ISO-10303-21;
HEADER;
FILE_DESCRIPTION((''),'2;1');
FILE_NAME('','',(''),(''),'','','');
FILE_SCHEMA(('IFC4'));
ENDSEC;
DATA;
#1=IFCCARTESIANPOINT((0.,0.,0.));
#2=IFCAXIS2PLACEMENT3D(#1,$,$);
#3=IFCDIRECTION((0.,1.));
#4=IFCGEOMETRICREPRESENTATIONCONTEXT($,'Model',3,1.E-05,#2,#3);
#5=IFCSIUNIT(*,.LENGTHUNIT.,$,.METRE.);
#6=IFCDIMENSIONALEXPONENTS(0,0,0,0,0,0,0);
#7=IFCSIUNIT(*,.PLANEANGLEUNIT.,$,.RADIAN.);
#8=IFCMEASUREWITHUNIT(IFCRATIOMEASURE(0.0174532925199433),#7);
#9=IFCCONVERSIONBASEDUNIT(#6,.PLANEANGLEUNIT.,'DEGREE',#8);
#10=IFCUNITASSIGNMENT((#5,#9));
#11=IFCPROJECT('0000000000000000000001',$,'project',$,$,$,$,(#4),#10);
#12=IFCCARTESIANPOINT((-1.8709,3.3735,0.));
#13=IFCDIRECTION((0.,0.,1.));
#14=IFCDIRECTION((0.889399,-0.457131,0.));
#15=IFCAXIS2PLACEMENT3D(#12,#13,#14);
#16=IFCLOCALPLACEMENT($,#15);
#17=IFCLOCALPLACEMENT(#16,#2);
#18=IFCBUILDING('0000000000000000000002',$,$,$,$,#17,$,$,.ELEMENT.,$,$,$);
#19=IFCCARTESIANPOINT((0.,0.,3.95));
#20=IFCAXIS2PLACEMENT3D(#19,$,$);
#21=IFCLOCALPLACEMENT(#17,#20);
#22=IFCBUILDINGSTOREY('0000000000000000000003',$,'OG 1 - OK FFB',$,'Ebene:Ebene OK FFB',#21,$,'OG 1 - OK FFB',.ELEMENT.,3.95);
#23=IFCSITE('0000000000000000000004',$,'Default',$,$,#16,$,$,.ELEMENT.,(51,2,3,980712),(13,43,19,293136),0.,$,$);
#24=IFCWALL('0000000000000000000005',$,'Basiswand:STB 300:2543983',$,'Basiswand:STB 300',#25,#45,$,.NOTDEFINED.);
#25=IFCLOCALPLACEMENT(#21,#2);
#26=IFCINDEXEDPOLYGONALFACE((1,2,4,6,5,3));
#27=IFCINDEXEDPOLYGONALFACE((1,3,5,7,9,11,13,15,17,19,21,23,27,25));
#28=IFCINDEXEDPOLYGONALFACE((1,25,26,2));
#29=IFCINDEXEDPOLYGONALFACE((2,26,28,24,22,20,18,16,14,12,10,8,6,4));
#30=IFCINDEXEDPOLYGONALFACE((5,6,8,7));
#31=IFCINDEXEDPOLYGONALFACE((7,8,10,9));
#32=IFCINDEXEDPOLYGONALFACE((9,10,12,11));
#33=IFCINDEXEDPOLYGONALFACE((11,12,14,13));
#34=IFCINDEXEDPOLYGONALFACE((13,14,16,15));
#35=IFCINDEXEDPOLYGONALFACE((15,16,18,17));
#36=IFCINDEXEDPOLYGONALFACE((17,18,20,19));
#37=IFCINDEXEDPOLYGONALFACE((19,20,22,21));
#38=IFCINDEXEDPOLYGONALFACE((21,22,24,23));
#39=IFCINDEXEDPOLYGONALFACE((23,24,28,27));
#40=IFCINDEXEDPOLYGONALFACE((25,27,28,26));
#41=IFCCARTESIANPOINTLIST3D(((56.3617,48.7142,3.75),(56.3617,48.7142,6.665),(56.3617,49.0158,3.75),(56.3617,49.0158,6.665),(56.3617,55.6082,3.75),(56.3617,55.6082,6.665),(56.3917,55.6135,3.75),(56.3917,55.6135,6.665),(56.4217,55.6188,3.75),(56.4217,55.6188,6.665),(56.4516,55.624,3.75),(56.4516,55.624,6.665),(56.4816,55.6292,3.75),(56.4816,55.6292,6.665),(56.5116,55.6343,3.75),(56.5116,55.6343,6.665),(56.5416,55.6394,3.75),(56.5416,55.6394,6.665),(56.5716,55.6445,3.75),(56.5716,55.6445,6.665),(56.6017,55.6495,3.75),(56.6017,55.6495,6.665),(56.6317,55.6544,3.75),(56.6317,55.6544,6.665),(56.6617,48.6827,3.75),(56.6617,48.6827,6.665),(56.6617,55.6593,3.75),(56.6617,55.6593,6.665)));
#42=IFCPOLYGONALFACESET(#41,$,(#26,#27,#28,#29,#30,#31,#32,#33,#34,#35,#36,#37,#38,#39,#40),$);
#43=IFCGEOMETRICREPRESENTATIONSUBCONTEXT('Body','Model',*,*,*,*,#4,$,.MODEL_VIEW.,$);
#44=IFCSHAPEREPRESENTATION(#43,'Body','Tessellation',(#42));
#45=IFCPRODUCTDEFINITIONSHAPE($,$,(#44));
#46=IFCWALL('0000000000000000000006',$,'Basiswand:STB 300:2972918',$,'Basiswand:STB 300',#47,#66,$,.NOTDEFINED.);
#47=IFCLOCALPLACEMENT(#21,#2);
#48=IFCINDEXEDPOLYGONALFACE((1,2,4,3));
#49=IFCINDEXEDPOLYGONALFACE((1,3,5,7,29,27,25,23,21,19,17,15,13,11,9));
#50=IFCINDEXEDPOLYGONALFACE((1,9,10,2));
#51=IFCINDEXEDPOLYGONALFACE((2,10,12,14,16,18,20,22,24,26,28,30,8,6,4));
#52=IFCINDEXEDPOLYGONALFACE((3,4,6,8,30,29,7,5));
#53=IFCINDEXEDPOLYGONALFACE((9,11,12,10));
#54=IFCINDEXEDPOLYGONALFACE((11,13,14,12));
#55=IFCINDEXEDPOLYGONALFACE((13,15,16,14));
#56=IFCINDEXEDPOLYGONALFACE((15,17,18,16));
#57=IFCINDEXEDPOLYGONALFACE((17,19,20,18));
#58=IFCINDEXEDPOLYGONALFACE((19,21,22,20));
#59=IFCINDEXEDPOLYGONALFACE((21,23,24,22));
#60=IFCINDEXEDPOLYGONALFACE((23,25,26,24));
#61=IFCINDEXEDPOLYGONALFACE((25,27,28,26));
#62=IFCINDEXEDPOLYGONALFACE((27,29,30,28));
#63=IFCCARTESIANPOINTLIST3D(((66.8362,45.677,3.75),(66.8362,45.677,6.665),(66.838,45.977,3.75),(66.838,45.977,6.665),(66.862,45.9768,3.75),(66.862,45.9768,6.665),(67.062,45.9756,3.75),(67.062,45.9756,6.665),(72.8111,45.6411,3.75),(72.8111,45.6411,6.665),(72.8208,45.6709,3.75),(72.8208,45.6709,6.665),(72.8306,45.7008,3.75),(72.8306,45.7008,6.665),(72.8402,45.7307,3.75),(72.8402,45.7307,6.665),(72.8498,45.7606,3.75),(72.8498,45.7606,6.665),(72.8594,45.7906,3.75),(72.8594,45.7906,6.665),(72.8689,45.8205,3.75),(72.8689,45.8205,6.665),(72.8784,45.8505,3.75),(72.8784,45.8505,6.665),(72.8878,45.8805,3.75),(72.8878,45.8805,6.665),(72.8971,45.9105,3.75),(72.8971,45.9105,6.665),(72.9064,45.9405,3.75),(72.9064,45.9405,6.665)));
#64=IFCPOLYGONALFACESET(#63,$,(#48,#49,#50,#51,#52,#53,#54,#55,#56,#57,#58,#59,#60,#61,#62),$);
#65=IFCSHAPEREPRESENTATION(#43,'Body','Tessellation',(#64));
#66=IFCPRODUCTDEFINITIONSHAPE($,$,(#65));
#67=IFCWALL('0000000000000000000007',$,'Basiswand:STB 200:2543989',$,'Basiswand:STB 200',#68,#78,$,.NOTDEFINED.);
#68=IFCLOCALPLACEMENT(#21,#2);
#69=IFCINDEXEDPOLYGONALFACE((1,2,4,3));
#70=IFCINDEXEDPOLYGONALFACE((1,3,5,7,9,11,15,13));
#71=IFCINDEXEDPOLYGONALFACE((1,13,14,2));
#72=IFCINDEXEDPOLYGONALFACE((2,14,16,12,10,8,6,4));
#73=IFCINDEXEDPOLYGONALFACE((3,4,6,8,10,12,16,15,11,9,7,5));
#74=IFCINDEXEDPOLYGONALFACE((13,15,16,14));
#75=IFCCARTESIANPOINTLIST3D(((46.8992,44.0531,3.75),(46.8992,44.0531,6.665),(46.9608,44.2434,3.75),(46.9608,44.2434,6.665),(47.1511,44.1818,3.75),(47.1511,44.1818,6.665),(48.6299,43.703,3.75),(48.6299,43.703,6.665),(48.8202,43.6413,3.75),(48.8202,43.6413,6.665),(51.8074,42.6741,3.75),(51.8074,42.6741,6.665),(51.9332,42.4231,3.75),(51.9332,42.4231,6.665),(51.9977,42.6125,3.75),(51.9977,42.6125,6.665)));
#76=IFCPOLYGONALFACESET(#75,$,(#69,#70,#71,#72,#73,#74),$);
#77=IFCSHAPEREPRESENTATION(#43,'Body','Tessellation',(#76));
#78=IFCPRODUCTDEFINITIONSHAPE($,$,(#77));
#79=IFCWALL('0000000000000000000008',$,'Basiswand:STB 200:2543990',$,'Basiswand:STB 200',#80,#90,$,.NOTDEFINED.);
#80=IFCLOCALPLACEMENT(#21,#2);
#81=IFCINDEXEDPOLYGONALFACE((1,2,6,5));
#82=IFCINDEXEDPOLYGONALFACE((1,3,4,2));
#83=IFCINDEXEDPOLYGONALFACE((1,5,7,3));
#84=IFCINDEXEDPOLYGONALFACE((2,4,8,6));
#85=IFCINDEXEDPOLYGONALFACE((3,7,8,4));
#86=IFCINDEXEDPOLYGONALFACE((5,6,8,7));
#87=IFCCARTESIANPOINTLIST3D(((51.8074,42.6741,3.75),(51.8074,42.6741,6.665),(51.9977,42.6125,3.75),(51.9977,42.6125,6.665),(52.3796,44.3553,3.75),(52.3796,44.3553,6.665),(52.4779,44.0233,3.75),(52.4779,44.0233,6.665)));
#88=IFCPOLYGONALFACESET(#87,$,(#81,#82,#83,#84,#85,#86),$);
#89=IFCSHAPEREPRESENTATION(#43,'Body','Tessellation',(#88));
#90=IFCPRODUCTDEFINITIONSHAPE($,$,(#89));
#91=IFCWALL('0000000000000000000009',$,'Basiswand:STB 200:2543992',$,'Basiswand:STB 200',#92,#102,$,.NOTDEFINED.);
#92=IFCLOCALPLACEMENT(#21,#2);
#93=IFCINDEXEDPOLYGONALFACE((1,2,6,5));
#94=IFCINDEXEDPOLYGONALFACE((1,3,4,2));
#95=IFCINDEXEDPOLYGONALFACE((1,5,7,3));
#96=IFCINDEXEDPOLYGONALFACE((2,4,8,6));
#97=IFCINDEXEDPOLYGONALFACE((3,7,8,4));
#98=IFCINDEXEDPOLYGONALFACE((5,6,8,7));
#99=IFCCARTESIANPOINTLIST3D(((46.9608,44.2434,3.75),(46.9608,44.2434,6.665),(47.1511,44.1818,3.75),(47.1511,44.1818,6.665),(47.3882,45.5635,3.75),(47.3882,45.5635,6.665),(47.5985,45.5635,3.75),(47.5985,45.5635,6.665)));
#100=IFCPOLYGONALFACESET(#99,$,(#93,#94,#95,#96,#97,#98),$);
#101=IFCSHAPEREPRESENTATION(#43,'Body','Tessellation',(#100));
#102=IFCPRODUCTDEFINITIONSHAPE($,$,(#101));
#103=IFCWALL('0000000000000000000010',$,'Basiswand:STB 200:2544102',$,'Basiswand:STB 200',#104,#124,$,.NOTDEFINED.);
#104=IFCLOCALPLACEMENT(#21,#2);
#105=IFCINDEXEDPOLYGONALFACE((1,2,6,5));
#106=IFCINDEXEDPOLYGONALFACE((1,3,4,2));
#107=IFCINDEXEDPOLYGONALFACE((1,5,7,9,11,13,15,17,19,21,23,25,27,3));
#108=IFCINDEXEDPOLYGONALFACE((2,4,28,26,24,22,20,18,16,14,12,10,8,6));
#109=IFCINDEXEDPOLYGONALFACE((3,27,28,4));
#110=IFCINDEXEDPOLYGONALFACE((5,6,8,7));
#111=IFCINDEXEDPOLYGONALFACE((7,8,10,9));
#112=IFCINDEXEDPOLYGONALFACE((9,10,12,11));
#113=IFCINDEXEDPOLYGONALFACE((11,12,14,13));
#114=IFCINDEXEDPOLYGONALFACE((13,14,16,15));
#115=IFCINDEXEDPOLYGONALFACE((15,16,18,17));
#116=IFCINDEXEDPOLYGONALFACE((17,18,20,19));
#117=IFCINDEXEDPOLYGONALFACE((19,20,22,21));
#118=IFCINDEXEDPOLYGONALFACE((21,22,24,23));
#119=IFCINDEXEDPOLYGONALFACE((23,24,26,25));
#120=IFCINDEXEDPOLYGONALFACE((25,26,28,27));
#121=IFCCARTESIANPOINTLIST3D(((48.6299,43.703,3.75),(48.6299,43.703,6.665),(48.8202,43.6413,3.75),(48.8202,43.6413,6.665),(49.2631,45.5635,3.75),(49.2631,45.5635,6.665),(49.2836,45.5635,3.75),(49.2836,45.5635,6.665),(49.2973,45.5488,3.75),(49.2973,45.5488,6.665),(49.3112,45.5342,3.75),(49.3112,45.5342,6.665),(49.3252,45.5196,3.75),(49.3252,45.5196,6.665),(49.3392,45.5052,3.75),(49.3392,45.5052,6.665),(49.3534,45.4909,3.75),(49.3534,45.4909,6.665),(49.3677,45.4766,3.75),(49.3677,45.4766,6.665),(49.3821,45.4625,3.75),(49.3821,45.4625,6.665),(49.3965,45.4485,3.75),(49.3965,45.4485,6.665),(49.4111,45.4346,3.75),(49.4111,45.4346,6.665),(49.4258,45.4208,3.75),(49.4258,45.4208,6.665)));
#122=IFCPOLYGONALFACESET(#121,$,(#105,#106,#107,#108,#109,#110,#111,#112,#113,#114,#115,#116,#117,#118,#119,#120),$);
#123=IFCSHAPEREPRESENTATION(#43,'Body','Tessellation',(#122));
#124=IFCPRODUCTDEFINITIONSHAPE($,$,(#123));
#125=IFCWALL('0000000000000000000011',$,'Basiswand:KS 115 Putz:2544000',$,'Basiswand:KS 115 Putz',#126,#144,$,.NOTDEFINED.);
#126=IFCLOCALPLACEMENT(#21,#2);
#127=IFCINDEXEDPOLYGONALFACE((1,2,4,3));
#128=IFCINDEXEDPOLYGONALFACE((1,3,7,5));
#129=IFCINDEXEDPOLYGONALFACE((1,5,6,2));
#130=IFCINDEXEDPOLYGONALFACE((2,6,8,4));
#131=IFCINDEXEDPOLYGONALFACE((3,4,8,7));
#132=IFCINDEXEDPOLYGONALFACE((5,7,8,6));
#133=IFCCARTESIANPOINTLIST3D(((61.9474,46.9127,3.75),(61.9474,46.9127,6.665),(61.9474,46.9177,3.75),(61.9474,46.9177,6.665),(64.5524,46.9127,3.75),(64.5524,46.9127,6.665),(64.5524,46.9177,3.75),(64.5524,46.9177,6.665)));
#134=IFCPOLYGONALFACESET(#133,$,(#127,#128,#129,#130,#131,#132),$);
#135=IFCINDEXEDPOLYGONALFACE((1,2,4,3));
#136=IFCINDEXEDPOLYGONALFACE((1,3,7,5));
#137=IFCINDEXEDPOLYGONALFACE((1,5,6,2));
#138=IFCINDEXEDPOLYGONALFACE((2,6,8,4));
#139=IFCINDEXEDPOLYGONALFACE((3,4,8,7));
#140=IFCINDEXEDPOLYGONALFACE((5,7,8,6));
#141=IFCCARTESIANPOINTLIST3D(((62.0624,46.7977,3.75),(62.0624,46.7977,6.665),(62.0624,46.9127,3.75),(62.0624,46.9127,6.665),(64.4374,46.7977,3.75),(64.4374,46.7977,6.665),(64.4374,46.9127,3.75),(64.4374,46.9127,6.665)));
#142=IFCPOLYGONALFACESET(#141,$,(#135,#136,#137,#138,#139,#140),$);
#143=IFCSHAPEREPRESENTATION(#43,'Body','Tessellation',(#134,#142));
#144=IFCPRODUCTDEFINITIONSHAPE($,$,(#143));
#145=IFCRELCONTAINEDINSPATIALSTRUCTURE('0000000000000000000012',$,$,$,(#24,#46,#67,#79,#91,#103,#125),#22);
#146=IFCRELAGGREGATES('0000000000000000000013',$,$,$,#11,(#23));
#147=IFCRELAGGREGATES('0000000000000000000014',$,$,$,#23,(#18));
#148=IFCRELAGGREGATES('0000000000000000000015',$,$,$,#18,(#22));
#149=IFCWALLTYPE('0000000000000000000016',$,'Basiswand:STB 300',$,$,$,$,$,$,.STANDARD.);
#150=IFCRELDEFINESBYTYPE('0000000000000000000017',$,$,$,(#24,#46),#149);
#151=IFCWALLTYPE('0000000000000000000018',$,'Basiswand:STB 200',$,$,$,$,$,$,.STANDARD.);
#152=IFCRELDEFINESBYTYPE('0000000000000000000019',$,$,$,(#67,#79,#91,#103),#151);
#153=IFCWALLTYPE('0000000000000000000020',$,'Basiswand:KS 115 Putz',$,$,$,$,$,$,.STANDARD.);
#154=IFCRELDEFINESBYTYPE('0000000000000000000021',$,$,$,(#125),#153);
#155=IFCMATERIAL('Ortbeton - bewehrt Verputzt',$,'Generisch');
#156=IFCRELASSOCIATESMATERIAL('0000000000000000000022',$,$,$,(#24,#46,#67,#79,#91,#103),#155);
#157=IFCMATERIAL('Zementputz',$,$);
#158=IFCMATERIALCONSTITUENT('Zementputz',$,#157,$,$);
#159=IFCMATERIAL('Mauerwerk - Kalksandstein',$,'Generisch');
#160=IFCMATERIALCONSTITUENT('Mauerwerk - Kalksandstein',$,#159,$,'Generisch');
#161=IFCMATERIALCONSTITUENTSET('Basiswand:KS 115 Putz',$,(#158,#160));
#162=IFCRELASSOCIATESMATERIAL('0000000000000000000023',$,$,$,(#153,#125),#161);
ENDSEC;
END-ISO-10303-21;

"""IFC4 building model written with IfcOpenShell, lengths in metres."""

from ifc_helpers import new_model, entity, si_unit, converted_unit, direction, frame, origin, place, context, subcontext, project, spatial, indexed_curve, outline, extrude, material, constituent, constituent_set, type_object, element, save


model = new_model("IFC4")

# Units and contexts
model_context = context("Model", 3, precision=1e-05, world=origin(), true_north=direction((0.0, 1.0)))
body_context = subcontext(model_context, "Body", "Model", "MODEL_VIEW")
ifc_project = project(units=[si_unit("LENGTHUNIT", "METRE"), converted_unit("PLANEANGLEUNIT", "DEGREE", entity("IfcRatioMeasure", 0.0174532925199433), si_unit("PLANEANGLEUNIT", "RADIAN"), dimensions=[0, 0, 0, 0, 0, 0, 0])], contexts=[model_context])

# Site, building, storey
site_placement = place(None, frame((-1.8709, 3.3735, 0.0), z_axis=(0.0, 0.0, 1.0), x_axis=(0.889399, -0.457131, 0.0)))
site = spatial("IfcSite", under=ifc_project, at=site_placement, Name="Default", CompositionType="ELEMENT", RefLatitude=(51, 2, 3, 980712), RefLongitude=(13, 43, 19, 293136), RefElevation=0.0)
building_placement = place(site_placement, origin())
building = spatial("IfcBuilding", under=site, at=building_placement, CompositionType="ELEMENT")
storey_placement = place(building_placement, frame((0.0, 0.0, 3.95)))
storey = spatial("IfcBuildingStorey", under=building, at=storey_placement, Name="OG 1 - OK FFB", ObjectType="Ebene:Ebene OK FFB", LongName="OG 1 - OK FFB", CompositionType="ELEMENT", Elevation=3.95)

# Shared definitions
ifc_material_1 = material(Name="Ortbeton - bewehrt Verputzt", Category="Generisch")

# Walls
wall_type_1 = type_object("IfcWallType", Name="Basiswand:STB 300", PredefinedType="STANDARD")
wall_1_placement = place(storey_placement, frame((56.5117, 48.6827, 3.75), z_axis=(0.0, 0.0, 1.0), x_axis=(0.0, 1.0, 0.0)))
element("IfcWall", 1, at=wall_1_placement, inside=storey, type_object=wall_type_1, material=ifc_material_1, Name="Basiswand:STB 300:2543983", ObjectType="Basiswand:STB 300", PredefinedType="NOTDEFINED", context=body_context, shape_type="SweptSolid", body=[
    extrude(outline(indexed_curve([(6.9767, -0.15), (6.9718, -0.12), (6.9668, -0.0899), (6.9618, -0.0599), (6.9568, -0.0299), (6.9517, 0.0001), (6.9465, 0.0301), (6.9414, 0.0601), (6.9361, 0.0901), (6.9308, 0.12), (6.9255, 0.15), (0.3332, 0.15), (0.0315, 0.15), (0.0, -0.15), (6.9767, -0.15)], self_intersect=False)), origin(), (0.0, 0.0, 1.0), 2.915),
])
wall_2_placement = place(storey_placement, frame((66.8371, 45.827, 3.75), z_axis=(0.0, 0.0, 1.0), x_axis=(0.999982, -0.006008, 0.0)))
element("IfcWall", 2, at=wall_2_placement, inside=storey, type_object=wall_type_1, material=ifc_material_1, Name="Basiswand:STB 300:2972918", ObjectType="Basiswand:STB 300", PredefinedType="NOTDEFINED", context=body_context, shape_type="SweptSolid", body=[
    extrude(outline(indexed_curve([(5.975, -0.15), (5.9846, -0.1201), (5.9941, -0.0901), (6.0036, -0.0602), (6.0131, -0.0302), (6.0225, -0.0002), (6.0318, 0.0298), (6.0411, 0.0598), (6.0503, 0.0899), (6.0595, 0.1199), (6.0686, 0.15), (0.224, 0.15), (0.024, 0.15), (0.0, 0.15), (0.0, -0.15), (5.975, -0.15)], self_intersect=False)), origin(), (0.0, 0.0, 1.0), 2.915),
])
wall_type_2 = type_object("IfcWallType", Name="Basiswand:STB 200", PredefinedType="STANDARD")
wall_3_placement = place(storey_placement, frame((51.9669, 42.5173, 3.75), z_axis=(0.0, 0.0, 1.0), x_axis=(-0.951371, 0.308048, 0.0)))
element("IfcWall", 3, at=wall_3_placement, inside=storey, type_object=wall_type_2, material=ifc_material_1, Name="Basiswand:STB 200:2543989", ObjectType="Basiswand:STB 200", PredefinedType="NOTDEFINED", context=body_context, shape_type="SweptSolid", body=[
    extrude(outline(indexed_curve([(5.2944, -0.1), (5.2944, 0.1), (0.003, 0.1), (0.0, -0.1), (0.2, -0.1), (3.3399, -0.1), (3.54, -0.1), (5.0944, -0.1), (5.2944, -0.1)], self_intersect=False)), origin(), (0.0, 0.0, 1.0), 2.915),
])
wall_4_placement = place(storey_placement, frame((51.9021, 42.6419, 3.75), z_axis=(0.0, 0.0, 1.0), x_axis=(0.322202, 0.946671, 0.0)))
element("IfcWall", 4, at=wall_4_placement, inside=storey, type_object=wall_type_2, material=ifc_material_1, Name="Basiswand:STB 200:2543990", ObjectType="Basiswand:STB 200", PredefinedType="NOTDEFINED", context=body_context, shape_type="SweptSolid", body=[
    extrude(outline(indexed_curve([(1.4932, -0.1), (1.7759, 0.1), (0.0, 0.1), (0.003, -0.1), (1.4932, -0.1)], self_intersect=False)), origin(), (0.0, 0.0, 1.0), 2.915),
])
wall_5_placement = place(storey_placement, frame((47.0559, 44.2126, 3.75), z_axis=(0.0, 0.0, 1.0), x_axis=(0.308048, 0.951371, 0.0)))
element("IfcWall", 5, at=wall_5_placement, inside=storey, type_object=wall_type_2, material=ifc_material_1, Name="Basiswand:STB 200:2543992", ObjectType="Basiswand:STB 200", PredefinedType="NOTDEFINED", context=body_context, shape_type="SweptSolid", body=[
    extrude(outline(indexed_curve([(1.4524, -0.1), (1.3876, 0.1), (0.0, 0.1), (0.0, -0.1), (1.4524, -0.1)], self_intersect=False)), origin(), (0.0, 0.0, 1.0), 2.915),
])
wall_6_placement = place(storey_placement, frame((49.3578, 45.5313, 3.75), z_axis=(0.0, 0.0, 1.0), x_axis=(-0.322202, -0.946671, 0.0)))
element("IfcWall", 6, at=wall_6_placement, inside=storey, type_object=wall_type_2, material=ifc_material_1, Name="Basiswand:STB 200:2544102", ObjectType="Basiswand:STB 200", PredefinedType="NOTDEFINED", context=body_context, shape_type="SweptSolid", body=[
    extrude(outline(indexed_curve([(1.9654, -0.1), (1.9624, 0.1), (0.0828, 0.1), (0.0744, 0.0817), (0.0659, 0.0634), (0.0573, 0.0451), (0.0486, 0.027), (0.0397, 0.0089), (0.0307, -0.0091), (0.0216, -0.0271), (0.0123, -0.045), (0.0029, -0.0629), (-0.0066, -0.0806), (0.0, -0.1), (1.9654, -0.1)], self_intersect=False)), origin(), (0.0, 0.0, 1.0), 2.915),
])
ifc_material_2 = material(Name="Zementputz")
ifc_constituent_1 = constituent(ifc_material_2, Name="Zementputz")
ifc_material_3 = material(Name="Mauerwerk - Kalksandstein", Category="Generisch")
ifc_constituent_2 = constituent(ifc_material_3, Name="Mauerwerk - Kalksandstein", Category="Generisch")
ifc_constituent_set_1 = constituent_set(constituents=[ifc_constituent_1, ifc_constituent_2], Name="Basiswand:KS 115 Putz")
wall_type_3 = type_object("IfcWallType", Name="Basiswand:KS 115 Putz", PredefinedType="STANDARD", material=ifc_constituent_set_1)
wall_7_placement = place(storey_placement, frame((62.0624, 46.8577, 3.75)))
element("IfcWall", 7, at=wall_7_placement, inside=storey, type_object=wall_type_3, material=ifc_constituent_set_1, Name="Basiswand:KS 115 Putz:2544000", ObjectType="Basiswand:KS 115 Putz", PredefinedType="NOTDEFINED", context=body_context, shape_type="SweptSolid", body=[
    extrude(outline(indexed_curve([(-0.0025, -1.3025), (0.0025, -1.3025), (0.0025, 1.3025), (-0.0025, 1.3025), (-0.0025, -1.3025)], self_intersect=False)), frame((1.1875, 0.0575, 0.0), z_axis=(0.0, 0.0, 1.0), x_axis=(0.0, -1.0, 0.0)), (0.0, 0.0, 1.0), 2.915),
    extrude(outline(indexed_curve([(-0.0575, -1.1875), (0.0575, -1.1875), (0.0575, 1.1875), (-0.0575, 1.1875), (-0.0575, -1.1875)], self_intersect=False)), frame((1.1875, -0.0025, 0.0), z_axis=(0.0, 0.0, 1.0), x_axis=(0.0, 1.0, 0.0)), (0.0, 0.0, 1.0), 2.915),
])

save(model, "model.ifc")
